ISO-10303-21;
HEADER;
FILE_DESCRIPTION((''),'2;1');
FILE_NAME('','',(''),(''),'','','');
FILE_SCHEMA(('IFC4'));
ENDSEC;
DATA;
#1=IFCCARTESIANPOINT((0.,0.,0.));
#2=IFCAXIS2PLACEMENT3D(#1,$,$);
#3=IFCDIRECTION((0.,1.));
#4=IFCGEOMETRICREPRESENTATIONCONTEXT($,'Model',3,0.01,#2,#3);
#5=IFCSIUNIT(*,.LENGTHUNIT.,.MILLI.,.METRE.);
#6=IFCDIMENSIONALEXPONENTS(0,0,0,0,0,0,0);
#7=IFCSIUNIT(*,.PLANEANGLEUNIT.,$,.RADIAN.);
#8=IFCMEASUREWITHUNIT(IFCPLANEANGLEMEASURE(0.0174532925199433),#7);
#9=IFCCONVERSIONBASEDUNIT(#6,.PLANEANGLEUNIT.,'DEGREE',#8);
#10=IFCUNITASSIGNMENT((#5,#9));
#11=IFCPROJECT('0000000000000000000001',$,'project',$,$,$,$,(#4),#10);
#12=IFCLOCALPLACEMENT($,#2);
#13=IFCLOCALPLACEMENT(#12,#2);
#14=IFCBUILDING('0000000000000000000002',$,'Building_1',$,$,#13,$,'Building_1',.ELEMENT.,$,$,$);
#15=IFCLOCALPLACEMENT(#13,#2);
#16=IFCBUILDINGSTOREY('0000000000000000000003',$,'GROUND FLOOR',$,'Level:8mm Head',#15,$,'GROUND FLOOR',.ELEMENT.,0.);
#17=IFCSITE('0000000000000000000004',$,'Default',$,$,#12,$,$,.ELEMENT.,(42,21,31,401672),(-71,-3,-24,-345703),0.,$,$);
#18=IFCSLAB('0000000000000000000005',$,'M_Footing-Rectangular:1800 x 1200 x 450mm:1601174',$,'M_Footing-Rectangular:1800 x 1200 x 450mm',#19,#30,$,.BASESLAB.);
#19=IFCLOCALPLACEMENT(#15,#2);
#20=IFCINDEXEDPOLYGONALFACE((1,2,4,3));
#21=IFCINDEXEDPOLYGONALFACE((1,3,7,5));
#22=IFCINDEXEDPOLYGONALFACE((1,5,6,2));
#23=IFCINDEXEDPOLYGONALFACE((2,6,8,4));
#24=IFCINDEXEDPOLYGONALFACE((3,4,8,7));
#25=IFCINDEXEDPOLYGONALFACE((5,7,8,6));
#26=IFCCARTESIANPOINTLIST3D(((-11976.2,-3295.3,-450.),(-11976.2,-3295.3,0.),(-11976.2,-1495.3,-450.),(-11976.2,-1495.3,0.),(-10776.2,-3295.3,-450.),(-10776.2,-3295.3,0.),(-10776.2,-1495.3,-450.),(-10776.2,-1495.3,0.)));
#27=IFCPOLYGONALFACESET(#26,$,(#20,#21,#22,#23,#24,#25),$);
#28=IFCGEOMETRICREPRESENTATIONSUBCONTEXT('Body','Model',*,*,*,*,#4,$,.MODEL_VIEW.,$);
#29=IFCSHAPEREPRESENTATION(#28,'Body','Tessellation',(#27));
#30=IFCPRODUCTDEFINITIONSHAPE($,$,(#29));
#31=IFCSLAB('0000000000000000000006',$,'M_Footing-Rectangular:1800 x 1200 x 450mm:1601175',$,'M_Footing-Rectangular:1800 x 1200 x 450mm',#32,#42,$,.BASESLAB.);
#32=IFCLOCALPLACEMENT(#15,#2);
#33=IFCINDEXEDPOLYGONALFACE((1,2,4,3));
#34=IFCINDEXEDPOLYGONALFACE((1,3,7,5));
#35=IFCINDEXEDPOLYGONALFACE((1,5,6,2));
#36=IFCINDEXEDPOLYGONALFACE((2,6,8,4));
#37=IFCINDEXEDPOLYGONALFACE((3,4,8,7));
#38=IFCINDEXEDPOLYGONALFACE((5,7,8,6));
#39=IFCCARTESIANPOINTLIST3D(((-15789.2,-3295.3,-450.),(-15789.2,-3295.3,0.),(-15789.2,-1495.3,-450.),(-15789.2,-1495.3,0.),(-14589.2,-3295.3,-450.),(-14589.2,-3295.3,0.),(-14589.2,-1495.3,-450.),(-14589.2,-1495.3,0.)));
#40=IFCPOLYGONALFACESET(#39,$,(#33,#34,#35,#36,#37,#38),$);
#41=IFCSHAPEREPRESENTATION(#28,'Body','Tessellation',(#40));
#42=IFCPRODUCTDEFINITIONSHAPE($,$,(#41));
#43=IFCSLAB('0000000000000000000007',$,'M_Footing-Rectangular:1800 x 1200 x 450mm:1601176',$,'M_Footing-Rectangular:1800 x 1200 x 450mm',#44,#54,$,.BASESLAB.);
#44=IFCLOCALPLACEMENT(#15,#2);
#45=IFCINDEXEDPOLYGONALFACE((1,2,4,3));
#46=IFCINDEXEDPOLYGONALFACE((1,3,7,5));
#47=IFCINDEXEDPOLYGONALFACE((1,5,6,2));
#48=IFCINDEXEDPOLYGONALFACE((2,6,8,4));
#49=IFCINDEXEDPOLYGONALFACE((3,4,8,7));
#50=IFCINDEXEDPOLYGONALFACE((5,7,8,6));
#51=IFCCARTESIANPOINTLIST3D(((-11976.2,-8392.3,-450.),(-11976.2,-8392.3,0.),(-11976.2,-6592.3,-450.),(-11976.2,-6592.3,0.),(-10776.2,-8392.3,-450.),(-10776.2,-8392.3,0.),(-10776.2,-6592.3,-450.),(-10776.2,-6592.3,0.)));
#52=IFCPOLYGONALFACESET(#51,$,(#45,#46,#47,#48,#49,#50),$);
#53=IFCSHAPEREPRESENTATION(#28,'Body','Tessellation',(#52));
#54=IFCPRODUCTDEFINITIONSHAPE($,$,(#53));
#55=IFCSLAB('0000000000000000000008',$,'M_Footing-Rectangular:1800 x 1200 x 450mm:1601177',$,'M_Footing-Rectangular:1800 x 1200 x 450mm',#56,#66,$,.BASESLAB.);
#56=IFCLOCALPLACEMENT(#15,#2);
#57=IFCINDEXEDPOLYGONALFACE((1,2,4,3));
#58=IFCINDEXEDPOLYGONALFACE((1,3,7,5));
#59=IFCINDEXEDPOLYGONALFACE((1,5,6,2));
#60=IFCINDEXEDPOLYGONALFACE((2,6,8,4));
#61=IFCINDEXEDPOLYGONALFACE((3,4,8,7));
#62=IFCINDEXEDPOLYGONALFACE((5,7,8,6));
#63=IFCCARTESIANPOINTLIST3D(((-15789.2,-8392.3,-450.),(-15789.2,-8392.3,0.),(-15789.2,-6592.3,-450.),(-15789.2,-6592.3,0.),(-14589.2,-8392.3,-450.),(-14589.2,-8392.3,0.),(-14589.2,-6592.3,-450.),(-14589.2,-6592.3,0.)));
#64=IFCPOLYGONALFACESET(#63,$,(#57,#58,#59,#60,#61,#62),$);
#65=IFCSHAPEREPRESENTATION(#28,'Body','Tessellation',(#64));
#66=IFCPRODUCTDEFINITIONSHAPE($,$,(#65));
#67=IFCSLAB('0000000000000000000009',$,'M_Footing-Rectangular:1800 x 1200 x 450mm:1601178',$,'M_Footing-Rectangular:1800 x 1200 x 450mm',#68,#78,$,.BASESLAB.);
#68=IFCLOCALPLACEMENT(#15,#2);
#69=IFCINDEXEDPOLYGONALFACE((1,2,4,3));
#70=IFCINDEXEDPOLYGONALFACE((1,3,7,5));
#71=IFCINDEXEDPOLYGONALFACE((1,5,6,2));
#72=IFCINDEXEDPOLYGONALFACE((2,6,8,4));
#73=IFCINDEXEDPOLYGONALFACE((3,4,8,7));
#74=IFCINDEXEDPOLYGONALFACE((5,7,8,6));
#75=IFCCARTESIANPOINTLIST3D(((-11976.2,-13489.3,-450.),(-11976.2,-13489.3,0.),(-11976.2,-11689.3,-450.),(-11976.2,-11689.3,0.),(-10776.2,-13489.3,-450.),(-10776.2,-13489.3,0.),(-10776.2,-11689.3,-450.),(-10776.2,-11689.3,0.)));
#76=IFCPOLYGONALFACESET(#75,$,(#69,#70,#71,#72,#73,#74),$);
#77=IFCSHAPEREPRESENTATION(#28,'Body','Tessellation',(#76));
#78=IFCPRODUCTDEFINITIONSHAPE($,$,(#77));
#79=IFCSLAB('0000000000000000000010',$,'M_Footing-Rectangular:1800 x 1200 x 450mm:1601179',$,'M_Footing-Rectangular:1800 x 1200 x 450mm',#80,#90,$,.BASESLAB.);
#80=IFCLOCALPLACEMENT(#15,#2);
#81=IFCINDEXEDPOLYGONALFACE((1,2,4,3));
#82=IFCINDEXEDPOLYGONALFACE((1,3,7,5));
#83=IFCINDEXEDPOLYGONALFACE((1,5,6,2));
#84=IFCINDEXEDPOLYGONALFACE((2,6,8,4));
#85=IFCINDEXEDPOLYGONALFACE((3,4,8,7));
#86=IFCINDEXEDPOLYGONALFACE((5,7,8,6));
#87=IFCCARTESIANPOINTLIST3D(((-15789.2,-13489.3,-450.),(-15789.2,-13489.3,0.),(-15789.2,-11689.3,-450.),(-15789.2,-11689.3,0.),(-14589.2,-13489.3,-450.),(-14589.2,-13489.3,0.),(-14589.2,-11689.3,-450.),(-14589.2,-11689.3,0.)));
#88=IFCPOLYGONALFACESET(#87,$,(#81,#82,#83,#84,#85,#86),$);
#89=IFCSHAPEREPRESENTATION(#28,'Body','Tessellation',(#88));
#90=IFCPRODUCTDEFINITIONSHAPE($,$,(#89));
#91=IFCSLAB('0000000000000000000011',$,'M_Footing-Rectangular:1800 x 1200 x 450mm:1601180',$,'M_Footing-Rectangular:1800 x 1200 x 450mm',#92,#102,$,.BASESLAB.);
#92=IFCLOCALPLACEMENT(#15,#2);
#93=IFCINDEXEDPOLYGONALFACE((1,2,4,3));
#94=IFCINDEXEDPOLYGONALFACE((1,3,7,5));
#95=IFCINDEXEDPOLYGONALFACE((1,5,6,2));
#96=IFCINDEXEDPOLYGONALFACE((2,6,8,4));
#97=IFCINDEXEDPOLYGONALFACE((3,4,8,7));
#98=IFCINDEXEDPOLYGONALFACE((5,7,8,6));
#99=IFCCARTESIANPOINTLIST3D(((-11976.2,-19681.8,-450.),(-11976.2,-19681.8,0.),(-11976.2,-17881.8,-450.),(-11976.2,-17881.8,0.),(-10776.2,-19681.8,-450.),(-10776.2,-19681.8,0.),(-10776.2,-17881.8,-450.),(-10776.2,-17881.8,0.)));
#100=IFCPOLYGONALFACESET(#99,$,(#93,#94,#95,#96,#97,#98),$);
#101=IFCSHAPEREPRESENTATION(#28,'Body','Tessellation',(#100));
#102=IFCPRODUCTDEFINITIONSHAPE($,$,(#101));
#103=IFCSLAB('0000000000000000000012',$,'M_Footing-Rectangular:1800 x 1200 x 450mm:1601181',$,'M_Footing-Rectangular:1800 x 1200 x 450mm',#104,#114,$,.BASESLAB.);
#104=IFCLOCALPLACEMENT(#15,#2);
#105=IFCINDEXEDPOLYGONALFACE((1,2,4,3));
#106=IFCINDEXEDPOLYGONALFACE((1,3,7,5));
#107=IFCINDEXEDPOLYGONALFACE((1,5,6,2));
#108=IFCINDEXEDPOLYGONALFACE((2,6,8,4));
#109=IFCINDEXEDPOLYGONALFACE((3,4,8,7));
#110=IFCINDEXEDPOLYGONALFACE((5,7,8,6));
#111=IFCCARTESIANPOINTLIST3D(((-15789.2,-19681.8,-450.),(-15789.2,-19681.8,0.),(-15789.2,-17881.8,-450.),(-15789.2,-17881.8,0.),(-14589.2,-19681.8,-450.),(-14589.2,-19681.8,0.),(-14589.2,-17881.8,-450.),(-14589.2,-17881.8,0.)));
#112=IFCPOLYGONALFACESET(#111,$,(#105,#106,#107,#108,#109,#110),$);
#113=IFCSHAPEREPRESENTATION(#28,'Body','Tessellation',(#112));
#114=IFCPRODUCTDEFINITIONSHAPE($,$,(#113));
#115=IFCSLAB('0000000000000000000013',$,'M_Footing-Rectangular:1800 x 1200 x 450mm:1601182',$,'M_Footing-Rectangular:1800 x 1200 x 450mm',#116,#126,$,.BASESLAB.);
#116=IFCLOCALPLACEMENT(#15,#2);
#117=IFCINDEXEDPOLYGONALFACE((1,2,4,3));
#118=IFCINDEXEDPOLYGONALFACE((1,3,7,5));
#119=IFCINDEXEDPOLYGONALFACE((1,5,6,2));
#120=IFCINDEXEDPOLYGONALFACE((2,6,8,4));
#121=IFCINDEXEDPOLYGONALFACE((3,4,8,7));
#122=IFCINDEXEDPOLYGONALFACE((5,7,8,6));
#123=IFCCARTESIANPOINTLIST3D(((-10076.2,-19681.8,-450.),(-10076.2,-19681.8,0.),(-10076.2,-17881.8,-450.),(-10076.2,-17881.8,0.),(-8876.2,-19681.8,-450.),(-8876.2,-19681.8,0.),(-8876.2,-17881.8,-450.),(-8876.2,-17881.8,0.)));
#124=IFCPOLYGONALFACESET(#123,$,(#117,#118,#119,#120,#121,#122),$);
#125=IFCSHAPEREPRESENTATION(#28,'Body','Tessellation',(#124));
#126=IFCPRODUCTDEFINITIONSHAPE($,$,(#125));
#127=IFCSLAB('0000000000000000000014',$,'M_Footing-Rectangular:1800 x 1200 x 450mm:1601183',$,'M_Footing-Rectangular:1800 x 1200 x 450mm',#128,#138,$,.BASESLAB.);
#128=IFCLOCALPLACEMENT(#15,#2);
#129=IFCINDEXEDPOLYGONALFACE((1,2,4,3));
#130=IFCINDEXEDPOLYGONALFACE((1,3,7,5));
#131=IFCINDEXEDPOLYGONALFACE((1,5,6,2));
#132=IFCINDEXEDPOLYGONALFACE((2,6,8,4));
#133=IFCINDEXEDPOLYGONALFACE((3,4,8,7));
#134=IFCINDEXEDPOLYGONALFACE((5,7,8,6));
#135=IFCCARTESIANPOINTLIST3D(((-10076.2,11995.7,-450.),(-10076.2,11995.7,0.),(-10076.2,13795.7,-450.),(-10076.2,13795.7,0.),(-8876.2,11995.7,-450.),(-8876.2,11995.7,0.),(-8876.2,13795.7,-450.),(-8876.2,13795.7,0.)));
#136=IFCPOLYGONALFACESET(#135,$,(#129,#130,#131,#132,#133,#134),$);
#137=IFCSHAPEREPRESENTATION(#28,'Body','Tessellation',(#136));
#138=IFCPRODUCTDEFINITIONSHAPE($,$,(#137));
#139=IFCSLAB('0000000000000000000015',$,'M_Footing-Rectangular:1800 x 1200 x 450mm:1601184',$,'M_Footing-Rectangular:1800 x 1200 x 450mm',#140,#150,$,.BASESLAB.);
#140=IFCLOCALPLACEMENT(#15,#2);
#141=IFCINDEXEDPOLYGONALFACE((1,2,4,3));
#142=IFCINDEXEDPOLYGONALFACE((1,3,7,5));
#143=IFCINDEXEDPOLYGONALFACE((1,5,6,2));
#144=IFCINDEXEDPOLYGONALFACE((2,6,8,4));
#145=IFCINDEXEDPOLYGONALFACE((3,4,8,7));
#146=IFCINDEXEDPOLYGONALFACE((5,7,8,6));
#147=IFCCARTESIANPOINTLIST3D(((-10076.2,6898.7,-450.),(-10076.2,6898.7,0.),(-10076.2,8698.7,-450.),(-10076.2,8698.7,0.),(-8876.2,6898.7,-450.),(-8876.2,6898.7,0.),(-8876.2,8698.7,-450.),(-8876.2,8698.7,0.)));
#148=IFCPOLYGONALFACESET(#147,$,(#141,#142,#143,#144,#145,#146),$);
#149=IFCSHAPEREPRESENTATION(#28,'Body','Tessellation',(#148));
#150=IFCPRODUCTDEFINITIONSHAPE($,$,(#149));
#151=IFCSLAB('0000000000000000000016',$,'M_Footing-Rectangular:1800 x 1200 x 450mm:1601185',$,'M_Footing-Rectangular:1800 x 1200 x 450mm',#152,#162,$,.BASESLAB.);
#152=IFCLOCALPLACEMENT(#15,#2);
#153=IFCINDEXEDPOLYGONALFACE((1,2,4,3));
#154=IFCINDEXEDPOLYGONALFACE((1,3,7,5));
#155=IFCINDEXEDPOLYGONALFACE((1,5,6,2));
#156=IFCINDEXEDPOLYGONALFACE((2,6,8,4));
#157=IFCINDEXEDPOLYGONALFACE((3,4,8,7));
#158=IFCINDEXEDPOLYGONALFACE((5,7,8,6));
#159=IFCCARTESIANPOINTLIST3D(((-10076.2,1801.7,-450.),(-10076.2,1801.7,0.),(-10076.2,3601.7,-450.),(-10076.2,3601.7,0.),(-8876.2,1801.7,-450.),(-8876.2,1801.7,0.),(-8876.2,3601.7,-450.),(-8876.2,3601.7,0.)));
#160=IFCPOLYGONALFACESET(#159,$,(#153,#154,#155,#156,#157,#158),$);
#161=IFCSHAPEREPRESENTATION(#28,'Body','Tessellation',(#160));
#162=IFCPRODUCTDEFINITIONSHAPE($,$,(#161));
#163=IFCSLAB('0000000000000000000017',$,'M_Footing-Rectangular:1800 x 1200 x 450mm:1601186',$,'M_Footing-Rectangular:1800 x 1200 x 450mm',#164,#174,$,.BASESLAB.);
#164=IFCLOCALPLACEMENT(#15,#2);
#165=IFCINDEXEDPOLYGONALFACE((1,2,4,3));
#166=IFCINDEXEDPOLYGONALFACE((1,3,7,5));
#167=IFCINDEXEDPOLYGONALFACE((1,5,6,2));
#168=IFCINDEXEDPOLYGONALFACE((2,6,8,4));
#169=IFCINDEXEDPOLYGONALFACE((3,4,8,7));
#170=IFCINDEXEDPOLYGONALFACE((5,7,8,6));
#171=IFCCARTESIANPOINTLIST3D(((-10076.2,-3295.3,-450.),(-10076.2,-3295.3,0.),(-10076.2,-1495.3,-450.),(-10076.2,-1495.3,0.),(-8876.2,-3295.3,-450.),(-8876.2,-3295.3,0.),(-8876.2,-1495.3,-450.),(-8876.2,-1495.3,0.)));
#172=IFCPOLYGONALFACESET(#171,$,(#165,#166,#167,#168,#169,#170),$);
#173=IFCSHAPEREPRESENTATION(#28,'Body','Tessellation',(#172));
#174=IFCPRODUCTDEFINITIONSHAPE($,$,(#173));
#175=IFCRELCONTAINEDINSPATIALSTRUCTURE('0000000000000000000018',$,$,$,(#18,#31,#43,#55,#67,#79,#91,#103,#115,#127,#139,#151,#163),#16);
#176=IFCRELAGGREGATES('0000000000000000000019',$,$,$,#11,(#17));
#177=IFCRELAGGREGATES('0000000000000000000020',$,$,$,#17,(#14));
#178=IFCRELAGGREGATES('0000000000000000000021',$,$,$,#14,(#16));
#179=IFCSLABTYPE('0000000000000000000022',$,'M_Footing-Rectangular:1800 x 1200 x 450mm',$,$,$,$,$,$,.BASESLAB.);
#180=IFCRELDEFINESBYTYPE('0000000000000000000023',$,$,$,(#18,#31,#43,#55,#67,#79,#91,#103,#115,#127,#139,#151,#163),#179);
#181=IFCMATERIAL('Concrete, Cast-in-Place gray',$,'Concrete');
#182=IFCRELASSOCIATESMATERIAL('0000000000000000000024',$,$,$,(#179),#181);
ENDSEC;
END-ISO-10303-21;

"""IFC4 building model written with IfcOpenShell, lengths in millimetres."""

from ifc_helpers import new_model, entity, si_unit, converted_unit, direction, frame, origin, place, context, subcontext, project, spatial, indexed_curve, outline, extrude, material, type_object, element, save


model = new_model("IFC4")

# Units and contexts
model_context = context("Model", 3, precision=0.01, world=origin(), true_north=direction((0.0, 1.0)))
body_context = subcontext(model_context, "Body", "Model", "MODEL_VIEW")
ifc_project = project(units=[si_unit("LENGTHUNIT", "METRE", prefix="MILLI"), converted_unit("PLANEANGLEUNIT", "DEGREE", entity("IfcPlaneAngleMeasure", 0.0174532925199433), si_unit("PLANEANGLEUNIT", "RADIAN"), dimensions=[0, 0, 0, 0, 0, 0, 0])], contexts=[model_context])

# Site, building, storey
site_placement = place(None, origin())
site = spatial("IfcSite", under=ifc_project, at=site_placement, Name="Default", CompositionType="ELEMENT", RefLatitude=(42, 21, 31, 401672), RefLongitude=(-71, -3, -24, -345703), RefElevation=0.0)
building_placement = place(site_placement, origin())
building = spatial("IfcBuilding", under=site, at=building_placement, Name="Building_1", LongName="Building_1", CompositionType="ELEMENT")
storey_placement = place(building_placement, origin())
storey = spatial("IfcBuildingStorey", under=building, at=storey_placement, Name="GROUND FLOOR", ObjectType="Level:8mm Head", LongName="GROUND FLOOR", CompositionType="ELEMENT", Elevation=0.0)

# Shared definitions
ifc_material_1 = material(Name="Concrete, Cast-in-Place gray", Category="Concrete")

# Slabs
slab_type_1 = type_object("IfcSlabType", Name="M_Footing-Rectangular:1800 x 1200 x 450mm", PredefinedType="BASESLAB", material=ifc_material_1)
slab_1_placement = place(storey_placement, origin())
element("IfcSlab", 1, at=slab_1_placement, inside=storey, type_object=slab_type_1, Name="M_Footing-Rectangular:1800 x 1200 x 450mm:1601174", ObjectType="M_Footing-Rectangular:1800 x 1200 x 450mm", PredefinedType="BASESLAB", context=body_context, shape_type="SweptSolid", body=[
    extrude(outline(indexed_curve([(-600.0, -900.0), (600.0, -900.0), (600.0, 900.0), (-600.0, 900.0), (-600.0, -900.0)], self_intersect=False)), frame((-11376.2, -2395.3, -450.0), z_axis=(0.0, 0.0, 1.0), x_axis=(-1.0, 0.0, 0.0)), (0.0, 0.0, 1.0), 450.0),
])
slab_2_placement = place(storey_placement, origin())
element("IfcSlab", 2, at=slab_2_placement, inside=storey, type_object=slab_type_1, Name="M_Footing-Rectangular:1800 x 1200 x 450mm:1601175", ObjectType="M_Footing-Rectangular:1800 x 1200 x 450mm", PredefinedType="BASESLAB", context=body_context, shape_type="SweptSolid", body=[
    extrude(outline(indexed_curve([(-600.0, -900.0), (600.0, -900.0), (600.0, 900.0), (-600.0, 900.0), (-600.0, -900.0)], self_intersect=False)), frame((-15189.2, -2395.3, -450.0), z_axis=(0.0, 0.0, 1.0), x_axis=(-1.0, 0.0, 0.0)), (0.0, 0.0, 1.0), 450.0),
])
slab_3_placement = place(storey_placement, origin())
element("IfcSlab", 3, at=slab_3_placement, inside=storey, type_object=slab_type_1, Name="M_Footing-Rectangular:1800 x 1200 x 450mm:1601176", ObjectType="M_Footing-Rectangular:1800 x 1200 x 450mm", PredefinedType="BASESLAB", context=body_context, shape_type="SweptSolid", body=[
    extrude(outline(indexed_curve([(-600.0, -900.0), (600.0, -900.0), (600.0, 900.0), (-600.0, 900.0), (-600.0, -900.0)], self_intersect=False)), frame((-11376.2, -7492.3, -450.0), z_axis=(0.0, 0.0, 1.0), x_axis=(-1.0, 0.0, 0.0)), (0.0, 0.0, 1.0), 450.0),
])
slab_4_placement = place(storey_placement, origin())
element("IfcSlab", 4, at=slab_4_placement, inside=storey, type_object=slab_type_1, Name="M_Footing-Rectangular:1800 x 1200 x 450mm:1601177", ObjectType="M_Footing-Rectangular:1800 x 1200 x 450mm", PredefinedType="BASESLAB", context=body_context, shape_type="SweptSolid", body=[
    extrude(outline(indexed_curve([(-600.0, -900.0), (600.0, -900.0), (600.0, 900.0), (-600.0, 900.0), (-600.0, -900.0)], self_intersect=False)), frame((-15189.2, -7492.3, -450.0), z_axis=(0.0, 0.0, 1.0), x_axis=(-1.0, 0.0, 0.0)), (0.0, 0.0, 1.0), 450.0),
])
slab_5_placement = place(storey_placement, origin())
element("IfcSlab", 5, at=slab_5_placement, inside=storey, type_object=slab_type_1, Name="M_Footing-Rectangular:1800 x 1200 x 450mm:1601178", ObjectType="M_Footing-Rectangular:1800 x 1200 x 450mm", PredefinedType="BASESLAB", context=body_context, shape_type="SweptSolid", body=[
    extrude(outline(indexed_curve([(-600.0, -900.0), (600.0, -900.0), (600.0, 900.0), (-600.0, 900.0), (-600.0, -900.0)], self_intersect=False)), frame((-11376.2, -12589.3, -450.0), z_axis=(0.0, 0.0, 1.0), x_axis=(-1.0, 0.0, 0.0)), (0.0, 0.0, 1.0), 450.0),
])
slab_6_placement = place(storey_placement, origin())
element("IfcSlab", 6, at=slab_6_placement, inside=storey, type_object=slab_type_1, Name="M_Footing-Rectangular:1800 x 1200 x 450mm:1601179", ObjectType="M_Footing-Rectangular:1800 x 1200 x 450mm", PredefinedType="BASESLAB", context=body_context, shape_type="SweptSolid", body=[
    extrude(outline(indexed_curve([(-600.0, -900.0), (600.0, -900.0), (600.0, 900.0), (-600.0, 900.0), (-600.0, -900.0)], self_intersect=False)), frame((-15189.2, -12589.3, -450.0), z_axis=(0.0, 0.0, 1.0), x_axis=(-1.0, 0.0, 0.0)), (0.0, 0.0, 1.0), 450.0),
])
slab_7_placement = place(storey_placement, origin())
element("IfcSlab", 7, at=slab_7_placement, inside=storey, type_object=slab_type_1, Name="M_Footing-Rectangular:1800 x 1200 x 450mm:1601180", ObjectType="M_Footing-Rectangular:1800 x 1200 x 450mm", PredefinedType="BASESLAB", context=body_context, shape_type="SweptSolid", body=[
    extrude(outline(indexed_curve([(-600.0, -900.0), (600.0, -900.0), (600.0, 900.0), (-600.0, 900.0), (-600.0, -900.0)], self_intersect=False)), frame((-11376.2, -18781.8, -450.0), z_axis=(0.0, 0.0, 1.0), x_axis=(-1.0, 0.0, 0.0)), (0.0, 0.0, 1.0), 450.0),
])
slab_8_placement = place(storey_placement, origin())
element("IfcSlab", 8, at=slab_8_placement, inside=storey, type_object=slab_type_1, Name="M_Footing-Rectangular:1800 x 1200 x 450mm:1601181", ObjectType="M_Footing-Rectangular:1800 x 1200 x 450mm", PredefinedType="BASESLAB", context=body_context, shape_type="SweptSolid", body=[
    extrude(outline(indexed_curve([(-600.0, -900.0), (600.0, -900.0), (600.0, 900.0), (-600.0, 900.0), (-600.0, -900.0)], self_intersect=False)), frame((-15189.2, -18781.8, -450.0), z_axis=(0.0, 0.0, 1.0), x_axis=(-1.0, 0.0, 0.0)), (0.0, 0.0, 1.0), 450.0),
])
slab_9_placement = place(storey_placement, origin())
element("IfcSlab", 9, at=slab_9_placement, inside=storey, type_object=slab_type_1, Name="M_Footing-Rectangular:1800 x 1200 x 450mm:1601182", ObjectType="M_Footing-Rectangular:1800 x 1200 x 450mm", PredefinedType="BASESLAB", context=body_context, shape_type="SweptSolid", body=[
    extrude(outline(indexed_curve([(-600.0, -900.0), (600.0, -900.0), (600.0, 900.0), (-600.0, 900.0), (-600.0, -900.0)], self_intersect=False)), frame((-9476.2, -18781.8, -450.0), z_axis=(0.0, 0.0, 1.0), x_axis=(-1.0, 0.0, 0.0)), (0.0, 0.0, 1.0), 450.0),
])
slab_10_placement = place(storey_placement, origin())
element("IfcSlab", 10, at=slab_10_placement, inside=storey, type_object=slab_type_1, Name="M_Footing-Rectangular:1800 x 1200 x 450mm:1601183", ObjectType="M_Footing-Rectangular:1800 x 1200 x 450mm", PredefinedType="BASESLAB", context=body_context, shape_type="SweptSolid", body=[
    extrude(outline(indexed_curve([(-600.0, -900.0), (600.0, -900.0), (600.0, 900.0), (-600.0, 900.0), (-600.0, -900.0)], self_intersect=False)), frame((-9476.2, 12895.7, -450.0), z_axis=(0.0, 0.0, 1.0), x_axis=(-1.0, 0.0, 0.0)), (0.0, 0.0, 1.0), 450.0),
])
slab_11_placement = place(storey_placement, origin())
element("IfcSlab", 11, at=slab_11_placement, inside=storey, type_object=slab_type_1, Name="M_Footing-Rectangular:1800 x 1200 x 450mm:1601184", ObjectType="M_Footing-Rectangular:1800 x 1200 x 450mm", PredefinedType="BASESLAB", context=body_context, shape_type="SweptSolid", body=[
    extrude(outline(indexed_curve([(-600.0, -900.0), (600.0, -900.0), (600.0, 900.0), (-600.0, 900.0), (-600.0, -900.0)], self_intersect=False)), frame((-9476.2, 7798.7, -450.0), z_axis=(0.0, 0.0, 1.0), x_axis=(-1.0, 0.0, 0.0)), (0.0, 0.0, 1.0), 450.0),
])
slab_12_placement = place(storey_placement, origin())
element("IfcSlab", 12, at=slab_12_placement, inside=storey, type_object=slab_type_1, Name="M_Footing-Rectangular:1800 x 1200 x 450mm:1601185", ObjectType="M_Footing-Rectangular:1800 x 1200 x 450mm", PredefinedType="BASESLAB", context=body_context, shape_type="SweptSolid", body=[
    extrude(outline(indexed_curve([(-600.0, -900.0), (600.0, -900.0), (600.0, 900.0), (-600.0, 900.0), (-600.0, -900.0)], self_intersect=False)), frame((-9476.2, 2701.7, -450.0), z_axis=(0.0, 0.0, 1.0), x_axis=(-1.0, 0.0, 0.0)), (0.0, 0.0, 1.0), 450.0),
])
slab_13_placement = place(storey_placement, origin())
element("IfcSlab", 13, at=slab_13_placement, inside=storey, type_object=slab_type_1, Name="M_Footing-Rectangular:1800 x 1200 x 450mm:1601186", ObjectType="M_Footing-Rectangular:1800 x 1200 x 450mm", PredefinedType="BASESLAB", context=body_context, shape_type="SweptSolid", body=[
    extrude(outline(indexed_curve([(-600.0, -900.0), (600.0, -900.0), (600.0, 900.0), (-600.0, 900.0), (-600.0, -900.0)], self_intersect=False)), frame((-9476.2, -2395.3, -450.0), z_axis=(0.0, 0.0, 1.0), x_axis=(-1.0, 0.0, 0.0)), (0.0, 0.0, 1.0), 450.0),
])

save(model, "model.ifc")
